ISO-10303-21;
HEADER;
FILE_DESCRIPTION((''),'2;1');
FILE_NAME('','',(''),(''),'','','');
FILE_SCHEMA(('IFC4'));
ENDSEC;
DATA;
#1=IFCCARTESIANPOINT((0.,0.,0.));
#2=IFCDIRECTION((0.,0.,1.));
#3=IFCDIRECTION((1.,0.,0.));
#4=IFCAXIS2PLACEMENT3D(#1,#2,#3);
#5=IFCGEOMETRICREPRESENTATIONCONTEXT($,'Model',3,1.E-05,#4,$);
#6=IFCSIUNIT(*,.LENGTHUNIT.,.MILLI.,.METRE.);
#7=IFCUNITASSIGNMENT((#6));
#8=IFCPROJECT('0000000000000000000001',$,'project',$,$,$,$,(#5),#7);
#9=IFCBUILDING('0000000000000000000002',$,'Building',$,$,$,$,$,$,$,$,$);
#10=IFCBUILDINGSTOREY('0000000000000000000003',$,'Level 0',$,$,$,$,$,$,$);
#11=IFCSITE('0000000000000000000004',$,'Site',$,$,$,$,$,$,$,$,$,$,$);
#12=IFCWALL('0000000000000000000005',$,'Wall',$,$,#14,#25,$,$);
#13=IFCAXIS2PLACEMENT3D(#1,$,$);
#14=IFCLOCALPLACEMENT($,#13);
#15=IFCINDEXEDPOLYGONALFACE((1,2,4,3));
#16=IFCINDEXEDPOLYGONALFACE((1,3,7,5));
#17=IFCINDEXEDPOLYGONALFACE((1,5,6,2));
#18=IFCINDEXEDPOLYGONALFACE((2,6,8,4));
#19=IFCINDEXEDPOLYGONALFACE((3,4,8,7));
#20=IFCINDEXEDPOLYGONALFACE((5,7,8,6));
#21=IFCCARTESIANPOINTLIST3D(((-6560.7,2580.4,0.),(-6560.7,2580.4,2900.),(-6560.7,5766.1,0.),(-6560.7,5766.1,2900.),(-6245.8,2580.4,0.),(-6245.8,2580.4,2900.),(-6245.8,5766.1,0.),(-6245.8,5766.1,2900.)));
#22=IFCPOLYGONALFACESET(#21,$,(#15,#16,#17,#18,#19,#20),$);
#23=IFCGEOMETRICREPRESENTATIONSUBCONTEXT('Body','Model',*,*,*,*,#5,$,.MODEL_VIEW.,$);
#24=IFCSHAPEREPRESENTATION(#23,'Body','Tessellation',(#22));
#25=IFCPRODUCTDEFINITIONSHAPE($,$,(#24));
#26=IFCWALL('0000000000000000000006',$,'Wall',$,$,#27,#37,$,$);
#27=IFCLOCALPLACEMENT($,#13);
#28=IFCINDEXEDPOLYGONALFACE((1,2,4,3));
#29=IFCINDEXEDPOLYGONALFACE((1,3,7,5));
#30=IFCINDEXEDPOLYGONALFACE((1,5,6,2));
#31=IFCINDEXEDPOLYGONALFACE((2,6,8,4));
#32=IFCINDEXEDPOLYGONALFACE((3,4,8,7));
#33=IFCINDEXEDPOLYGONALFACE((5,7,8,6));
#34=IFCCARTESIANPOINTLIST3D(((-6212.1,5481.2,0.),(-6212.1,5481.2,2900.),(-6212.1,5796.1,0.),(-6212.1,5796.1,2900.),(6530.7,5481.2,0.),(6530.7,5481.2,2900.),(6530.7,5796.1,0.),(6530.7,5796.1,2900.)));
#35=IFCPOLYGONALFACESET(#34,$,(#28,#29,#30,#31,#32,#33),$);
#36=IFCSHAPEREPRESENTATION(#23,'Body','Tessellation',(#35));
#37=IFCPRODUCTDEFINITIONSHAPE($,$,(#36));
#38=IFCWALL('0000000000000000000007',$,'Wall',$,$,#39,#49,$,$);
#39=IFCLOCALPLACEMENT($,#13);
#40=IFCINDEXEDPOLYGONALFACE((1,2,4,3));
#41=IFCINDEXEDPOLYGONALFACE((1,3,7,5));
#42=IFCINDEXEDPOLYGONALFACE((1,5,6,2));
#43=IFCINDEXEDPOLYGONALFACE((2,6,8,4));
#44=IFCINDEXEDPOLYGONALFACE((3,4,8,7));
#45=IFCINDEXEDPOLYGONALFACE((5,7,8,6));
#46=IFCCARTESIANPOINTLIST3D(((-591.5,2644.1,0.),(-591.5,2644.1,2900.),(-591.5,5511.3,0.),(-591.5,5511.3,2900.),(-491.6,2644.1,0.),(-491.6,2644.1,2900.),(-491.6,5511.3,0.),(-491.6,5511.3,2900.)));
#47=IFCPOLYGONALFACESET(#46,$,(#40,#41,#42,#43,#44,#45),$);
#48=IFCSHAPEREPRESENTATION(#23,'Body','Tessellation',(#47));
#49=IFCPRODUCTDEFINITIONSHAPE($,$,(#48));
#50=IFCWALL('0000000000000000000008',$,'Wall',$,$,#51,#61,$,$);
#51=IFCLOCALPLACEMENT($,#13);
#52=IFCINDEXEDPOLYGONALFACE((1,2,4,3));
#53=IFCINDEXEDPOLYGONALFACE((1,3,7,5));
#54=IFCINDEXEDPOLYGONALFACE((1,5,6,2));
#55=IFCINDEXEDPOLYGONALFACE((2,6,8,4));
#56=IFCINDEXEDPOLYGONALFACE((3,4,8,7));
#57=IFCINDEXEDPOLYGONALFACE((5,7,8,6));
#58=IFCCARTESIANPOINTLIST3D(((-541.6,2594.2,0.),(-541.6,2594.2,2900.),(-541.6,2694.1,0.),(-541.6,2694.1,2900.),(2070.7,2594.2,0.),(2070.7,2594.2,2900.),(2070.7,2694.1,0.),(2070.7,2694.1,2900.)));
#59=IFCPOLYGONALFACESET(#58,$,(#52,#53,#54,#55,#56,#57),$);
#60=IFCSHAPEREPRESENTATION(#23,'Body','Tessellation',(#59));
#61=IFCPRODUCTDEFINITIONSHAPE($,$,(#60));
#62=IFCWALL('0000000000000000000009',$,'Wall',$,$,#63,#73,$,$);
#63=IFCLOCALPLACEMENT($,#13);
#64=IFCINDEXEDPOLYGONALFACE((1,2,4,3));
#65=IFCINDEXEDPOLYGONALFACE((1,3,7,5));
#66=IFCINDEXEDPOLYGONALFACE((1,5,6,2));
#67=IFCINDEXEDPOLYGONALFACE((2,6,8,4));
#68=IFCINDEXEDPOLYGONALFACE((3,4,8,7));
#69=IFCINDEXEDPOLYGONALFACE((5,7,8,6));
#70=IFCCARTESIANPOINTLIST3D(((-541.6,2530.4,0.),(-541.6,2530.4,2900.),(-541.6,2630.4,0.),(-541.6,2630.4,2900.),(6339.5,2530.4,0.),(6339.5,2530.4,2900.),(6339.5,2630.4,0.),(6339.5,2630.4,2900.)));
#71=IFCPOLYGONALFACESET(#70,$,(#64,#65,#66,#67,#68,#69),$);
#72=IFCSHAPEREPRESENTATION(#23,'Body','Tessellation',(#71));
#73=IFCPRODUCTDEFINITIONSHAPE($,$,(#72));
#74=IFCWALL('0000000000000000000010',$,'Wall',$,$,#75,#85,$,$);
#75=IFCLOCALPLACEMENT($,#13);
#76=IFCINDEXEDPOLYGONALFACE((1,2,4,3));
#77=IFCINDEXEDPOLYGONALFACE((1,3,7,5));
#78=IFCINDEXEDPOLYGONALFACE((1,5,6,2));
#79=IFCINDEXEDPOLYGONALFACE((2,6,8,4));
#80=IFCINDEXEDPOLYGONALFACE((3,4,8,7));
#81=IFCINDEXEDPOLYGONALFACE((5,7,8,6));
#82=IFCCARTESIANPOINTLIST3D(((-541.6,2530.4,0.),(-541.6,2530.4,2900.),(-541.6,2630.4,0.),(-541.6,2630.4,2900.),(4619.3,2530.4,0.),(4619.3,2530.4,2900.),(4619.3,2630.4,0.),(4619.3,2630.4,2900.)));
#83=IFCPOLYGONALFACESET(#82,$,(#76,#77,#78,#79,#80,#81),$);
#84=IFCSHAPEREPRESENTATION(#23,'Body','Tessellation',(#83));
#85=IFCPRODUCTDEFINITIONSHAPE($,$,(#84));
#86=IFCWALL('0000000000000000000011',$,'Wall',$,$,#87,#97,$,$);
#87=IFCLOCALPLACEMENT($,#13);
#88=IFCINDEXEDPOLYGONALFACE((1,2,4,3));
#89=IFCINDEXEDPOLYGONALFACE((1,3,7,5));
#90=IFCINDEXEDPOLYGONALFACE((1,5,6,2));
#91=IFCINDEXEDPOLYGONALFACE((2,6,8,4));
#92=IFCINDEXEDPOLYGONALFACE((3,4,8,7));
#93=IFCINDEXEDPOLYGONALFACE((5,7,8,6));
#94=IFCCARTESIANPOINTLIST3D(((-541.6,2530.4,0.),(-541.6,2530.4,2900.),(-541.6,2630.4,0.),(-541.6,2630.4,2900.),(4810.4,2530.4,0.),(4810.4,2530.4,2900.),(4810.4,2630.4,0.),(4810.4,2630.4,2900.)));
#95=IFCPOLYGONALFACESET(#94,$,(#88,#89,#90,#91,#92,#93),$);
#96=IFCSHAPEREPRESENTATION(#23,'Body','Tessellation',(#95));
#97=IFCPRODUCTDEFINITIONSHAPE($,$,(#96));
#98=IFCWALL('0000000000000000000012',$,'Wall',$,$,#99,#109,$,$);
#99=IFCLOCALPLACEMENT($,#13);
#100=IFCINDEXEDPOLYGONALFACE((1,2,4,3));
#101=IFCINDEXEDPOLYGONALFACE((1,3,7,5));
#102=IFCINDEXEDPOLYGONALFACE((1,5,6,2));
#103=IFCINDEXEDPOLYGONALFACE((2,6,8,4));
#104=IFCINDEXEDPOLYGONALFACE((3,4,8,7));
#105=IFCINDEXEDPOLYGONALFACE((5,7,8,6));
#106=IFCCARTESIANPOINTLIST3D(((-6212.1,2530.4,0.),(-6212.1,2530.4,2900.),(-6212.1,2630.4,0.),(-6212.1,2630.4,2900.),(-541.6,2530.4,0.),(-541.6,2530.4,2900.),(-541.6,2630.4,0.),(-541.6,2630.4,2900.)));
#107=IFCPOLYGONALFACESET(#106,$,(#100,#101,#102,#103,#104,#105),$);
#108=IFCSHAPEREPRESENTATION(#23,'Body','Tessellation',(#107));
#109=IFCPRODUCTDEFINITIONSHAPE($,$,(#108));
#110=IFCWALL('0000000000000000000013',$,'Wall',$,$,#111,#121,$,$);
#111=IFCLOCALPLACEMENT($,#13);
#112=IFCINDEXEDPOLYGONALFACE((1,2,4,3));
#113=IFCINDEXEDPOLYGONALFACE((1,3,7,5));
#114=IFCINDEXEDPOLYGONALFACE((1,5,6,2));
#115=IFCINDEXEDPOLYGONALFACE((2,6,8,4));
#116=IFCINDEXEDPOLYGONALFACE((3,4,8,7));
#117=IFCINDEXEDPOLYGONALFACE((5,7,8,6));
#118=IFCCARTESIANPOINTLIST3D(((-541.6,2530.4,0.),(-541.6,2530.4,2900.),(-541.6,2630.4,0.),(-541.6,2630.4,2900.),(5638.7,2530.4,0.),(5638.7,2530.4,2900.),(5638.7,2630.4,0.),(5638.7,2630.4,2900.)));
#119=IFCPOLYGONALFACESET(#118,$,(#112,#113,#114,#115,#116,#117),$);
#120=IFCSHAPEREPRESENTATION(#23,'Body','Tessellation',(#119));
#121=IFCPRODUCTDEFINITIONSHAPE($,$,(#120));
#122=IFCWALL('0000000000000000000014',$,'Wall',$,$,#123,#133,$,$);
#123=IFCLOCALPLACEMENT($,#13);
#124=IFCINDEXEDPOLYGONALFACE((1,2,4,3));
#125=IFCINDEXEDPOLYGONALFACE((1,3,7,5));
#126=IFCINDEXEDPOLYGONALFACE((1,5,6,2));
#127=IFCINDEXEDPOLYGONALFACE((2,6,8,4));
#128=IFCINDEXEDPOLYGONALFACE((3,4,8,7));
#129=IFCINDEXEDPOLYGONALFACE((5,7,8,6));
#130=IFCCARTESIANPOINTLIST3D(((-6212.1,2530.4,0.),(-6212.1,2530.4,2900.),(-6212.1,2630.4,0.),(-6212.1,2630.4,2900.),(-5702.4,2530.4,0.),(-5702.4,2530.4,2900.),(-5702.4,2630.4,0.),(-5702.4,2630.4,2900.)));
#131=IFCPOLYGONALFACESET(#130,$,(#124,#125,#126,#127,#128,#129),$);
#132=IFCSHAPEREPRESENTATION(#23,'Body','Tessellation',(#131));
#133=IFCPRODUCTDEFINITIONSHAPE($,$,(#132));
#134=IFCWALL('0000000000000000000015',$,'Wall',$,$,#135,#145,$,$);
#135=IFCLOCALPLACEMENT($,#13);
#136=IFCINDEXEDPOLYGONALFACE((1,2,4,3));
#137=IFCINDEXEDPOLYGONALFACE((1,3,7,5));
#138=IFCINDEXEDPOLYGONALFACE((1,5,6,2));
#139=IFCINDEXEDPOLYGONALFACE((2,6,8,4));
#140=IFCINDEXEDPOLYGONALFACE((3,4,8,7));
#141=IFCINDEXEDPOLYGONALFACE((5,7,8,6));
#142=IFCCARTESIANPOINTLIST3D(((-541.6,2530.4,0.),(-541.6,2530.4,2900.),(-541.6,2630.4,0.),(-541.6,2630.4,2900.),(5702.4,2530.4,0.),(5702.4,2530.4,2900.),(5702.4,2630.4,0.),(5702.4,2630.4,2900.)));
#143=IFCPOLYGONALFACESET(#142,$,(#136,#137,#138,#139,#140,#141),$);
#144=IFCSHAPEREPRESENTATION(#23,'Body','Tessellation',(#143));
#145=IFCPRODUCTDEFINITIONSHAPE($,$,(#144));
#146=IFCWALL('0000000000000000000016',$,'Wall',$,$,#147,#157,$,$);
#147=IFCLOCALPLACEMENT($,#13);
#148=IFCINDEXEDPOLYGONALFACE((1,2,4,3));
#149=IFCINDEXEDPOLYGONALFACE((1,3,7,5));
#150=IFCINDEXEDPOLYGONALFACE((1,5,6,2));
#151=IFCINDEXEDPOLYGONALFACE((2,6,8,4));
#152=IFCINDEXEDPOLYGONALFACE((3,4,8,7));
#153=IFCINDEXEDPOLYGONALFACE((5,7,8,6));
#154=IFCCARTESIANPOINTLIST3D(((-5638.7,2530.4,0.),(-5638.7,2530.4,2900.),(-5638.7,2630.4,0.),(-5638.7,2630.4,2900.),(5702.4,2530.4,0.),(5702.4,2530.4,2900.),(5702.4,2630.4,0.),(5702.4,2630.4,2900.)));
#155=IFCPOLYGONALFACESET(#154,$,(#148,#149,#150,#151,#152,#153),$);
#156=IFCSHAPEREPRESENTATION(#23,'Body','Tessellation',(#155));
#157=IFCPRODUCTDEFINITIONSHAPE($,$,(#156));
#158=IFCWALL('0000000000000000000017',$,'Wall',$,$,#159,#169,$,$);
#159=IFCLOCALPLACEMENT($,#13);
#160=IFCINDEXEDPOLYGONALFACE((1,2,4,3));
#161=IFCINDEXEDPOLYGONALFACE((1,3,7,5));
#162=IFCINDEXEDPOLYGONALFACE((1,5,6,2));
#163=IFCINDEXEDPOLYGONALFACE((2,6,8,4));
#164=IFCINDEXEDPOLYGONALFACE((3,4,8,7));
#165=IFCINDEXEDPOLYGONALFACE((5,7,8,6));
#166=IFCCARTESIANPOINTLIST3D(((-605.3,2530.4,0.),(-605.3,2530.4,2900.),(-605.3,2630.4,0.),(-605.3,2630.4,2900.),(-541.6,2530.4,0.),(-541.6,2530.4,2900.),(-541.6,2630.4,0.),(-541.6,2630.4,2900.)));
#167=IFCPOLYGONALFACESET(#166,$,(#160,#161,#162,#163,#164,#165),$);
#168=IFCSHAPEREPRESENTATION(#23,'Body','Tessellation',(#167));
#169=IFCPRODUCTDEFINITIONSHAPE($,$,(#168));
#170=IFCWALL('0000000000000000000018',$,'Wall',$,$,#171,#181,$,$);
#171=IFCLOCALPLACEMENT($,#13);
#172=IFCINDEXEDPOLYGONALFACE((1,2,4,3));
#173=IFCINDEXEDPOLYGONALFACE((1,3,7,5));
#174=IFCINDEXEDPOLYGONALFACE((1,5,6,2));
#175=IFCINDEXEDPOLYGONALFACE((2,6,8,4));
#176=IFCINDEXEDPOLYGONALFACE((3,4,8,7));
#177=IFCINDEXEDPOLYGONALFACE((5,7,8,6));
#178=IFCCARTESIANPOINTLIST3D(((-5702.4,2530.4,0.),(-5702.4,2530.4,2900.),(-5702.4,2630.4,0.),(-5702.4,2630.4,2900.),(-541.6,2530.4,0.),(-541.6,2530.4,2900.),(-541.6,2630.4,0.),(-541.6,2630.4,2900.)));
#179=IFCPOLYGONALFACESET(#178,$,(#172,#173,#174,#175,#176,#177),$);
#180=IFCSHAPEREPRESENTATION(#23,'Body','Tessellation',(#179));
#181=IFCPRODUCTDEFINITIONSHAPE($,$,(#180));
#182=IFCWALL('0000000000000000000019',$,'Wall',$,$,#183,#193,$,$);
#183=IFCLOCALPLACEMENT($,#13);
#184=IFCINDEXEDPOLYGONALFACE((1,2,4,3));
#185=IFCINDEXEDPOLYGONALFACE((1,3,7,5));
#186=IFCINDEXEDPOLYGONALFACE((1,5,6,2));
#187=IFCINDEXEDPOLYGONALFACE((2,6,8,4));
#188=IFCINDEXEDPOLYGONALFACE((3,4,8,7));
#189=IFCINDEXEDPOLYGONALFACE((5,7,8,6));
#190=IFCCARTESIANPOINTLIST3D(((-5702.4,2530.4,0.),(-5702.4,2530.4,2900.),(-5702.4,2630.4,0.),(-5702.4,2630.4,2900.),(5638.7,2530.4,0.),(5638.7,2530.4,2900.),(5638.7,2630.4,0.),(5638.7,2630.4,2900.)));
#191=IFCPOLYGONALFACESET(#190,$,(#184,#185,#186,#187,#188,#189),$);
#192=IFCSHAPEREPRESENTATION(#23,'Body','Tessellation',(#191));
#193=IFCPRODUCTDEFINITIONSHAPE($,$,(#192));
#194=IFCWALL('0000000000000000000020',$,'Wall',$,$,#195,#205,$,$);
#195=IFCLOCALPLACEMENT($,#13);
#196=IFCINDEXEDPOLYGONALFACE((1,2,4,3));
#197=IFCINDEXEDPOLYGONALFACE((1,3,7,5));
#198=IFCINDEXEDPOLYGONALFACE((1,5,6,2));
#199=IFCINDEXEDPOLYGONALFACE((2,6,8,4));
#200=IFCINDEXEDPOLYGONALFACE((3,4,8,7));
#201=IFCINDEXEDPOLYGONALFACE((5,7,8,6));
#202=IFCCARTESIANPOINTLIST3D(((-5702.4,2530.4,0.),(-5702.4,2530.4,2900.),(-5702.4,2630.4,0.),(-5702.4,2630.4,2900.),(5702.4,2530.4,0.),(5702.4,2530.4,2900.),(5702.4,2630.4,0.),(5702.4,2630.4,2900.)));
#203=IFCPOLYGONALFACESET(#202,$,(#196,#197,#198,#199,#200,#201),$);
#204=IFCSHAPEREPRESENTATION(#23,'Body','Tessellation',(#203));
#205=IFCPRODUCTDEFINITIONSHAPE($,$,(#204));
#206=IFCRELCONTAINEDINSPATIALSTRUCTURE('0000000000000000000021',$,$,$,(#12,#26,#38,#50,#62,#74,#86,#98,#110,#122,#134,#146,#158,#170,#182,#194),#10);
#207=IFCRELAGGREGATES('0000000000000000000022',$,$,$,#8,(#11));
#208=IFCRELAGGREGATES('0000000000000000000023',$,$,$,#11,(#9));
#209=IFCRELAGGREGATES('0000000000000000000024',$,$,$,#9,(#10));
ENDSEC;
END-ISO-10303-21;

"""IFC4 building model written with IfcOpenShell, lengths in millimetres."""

from ifc_helpers import new_model, si_unit, frame, origin_with_axes, place, context, subcontext, project, spatial, indexed_curve, outline, extrude, element, save


model = new_model("IFC4")

# Units and contexts
model_context = context("Model", 3, precision=1e-05, world=origin_with_axes())
body_context = subcontext(model_context, "Body", "Model", "MODEL_VIEW")
ifc_project = project(units=[si_unit("LENGTHUNIT", "METRE", prefix="MILLI")], contexts=[model_context])

# Site, building, storey
site = spatial("IfcSite", under=ifc_project, Name="Site")
building = spatial("IfcBuilding", under=site, Name="Building")
storey = spatial("IfcBuildingStorey", under=building, Name="Level 0")

# Walls
wall_1_placement = place(None, frame((-6560.7, 5766.1, 0.0), z_axis=(0.0, 0.0, 1.0), x_axis=(0.0, -1.0, 0.0)))
element("IfcWall", 1, at=wall_1_placement, inside=storey, Name="Wall", context=body_context, shape_type="SweptSolid", body=[
    extrude(outline(indexed_curve([(0.0, 0.0), (0.0, 314.9), (3185.7, 314.9), (3185.7, 0.0), (0.0, 0.0)], self_intersect=False)), origin_with_axes(), (0.0, 0.0, 1.0), 2900.0),
])
wall_2_placement = place(None, frame((-6212.1, 5481.2, 0.0), z_axis=(0.0, 0.0, 1.0), x_axis=(1.0, 0.0, 0.0)))
element("IfcWall", 2, at=wall_2_placement, inside=storey, Name="Wall", context=body_context, shape_type="SweptSolid", body=[
    extrude(outline(indexed_curve([(0.0, 0.0), (0.0, 314.9), (12742.8, 314.9), (12742.8, 0.0), (0.0, 0.0)], self_intersect=False)), origin_with_axes(), (0.0, 0.0, 1.0), 2900.0),
])
wall_3_placement = place(None, frame((-591.5, 5511.3, 0.0), z_axis=(0.0, 0.0, 1.0), x_axis=(0.0, -1.0, 0.0)))
element("IfcWall", 3, at=wall_3_placement, inside=storey, Name="Wall", context=body_context, shape_type="SweptSolid", body=[
    extrude(outline(indexed_curve([(0.0, 0.0), (0.0, 99.9), (2867.1, 99.9), (2867.1, 0.0), (0.0, 0.0)], self_intersect=False)), origin_with_axes(), (0.0, 0.0, 1.0), 2900.0),
])
wall_4_placement = place(None, frame((-541.6, 2594.2, 0.0), z_axis=(0.0, 0.0, 1.0), x_axis=(1.0, 0.0, 0.0)))
element("IfcWall", 4, at=wall_4_placement, inside=storey, Name="Wall", context=body_context, shape_type="SweptSolid", body=[
    extrude(outline(indexed_curve([(0.0, 0.0), (0.0, 99.9), (2612.3, 99.9), (2612.3, 0.0), (0.0, 0.0)], self_intersect=False)), origin_with_axes(), (0.0, 0.0, 1.0), 2900.0),
])
wall_5_placement = place(None, frame((-541.6, 2530.4, 0.0), z_axis=(0.0, 0.0, 1.0), x_axis=(1.0, 0.0, 0.0)))
element("IfcWall", 5, at=wall_5_placement, inside=storey, Name="Wall", context=body_context, shape_type="SweptSolid", body=[
    extrude(outline(indexed_curve([(0.0, 0.0), (0.0, 99.9), (6881.1, 99.9), (6881.1, 0.0), (0.0, 0.0)], self_intersect=False)), origin_with_axes(), (0.0, 0.0, 1.0), 2900.0),
])
wall_6_placement = place(None, frame((-541.6, 2530.4, 0.0), z_axis=(0.0, 0.0, 1.0), x_axis=(1.0, 0.0, 0.0)))
element("IfcWall", 6, at=wall_6_placement, inside=storey, Name="Wall", context=body_context, shape_type="SweptSolid", body=[
    extrude(outline(indexed_curve([(0.0, 0.0), (0.0, 99.9), (5160.8, 99.9), (5160.8, 0.0), (0.0, 0.0)], self_intersect=False)), origin_with_axes(), (0.0, 0.0, 1.0), 2900.0),
])
for number, where, z_axis, x_axis, name in (
    (7, (-541.6, 2530.4, 0.0), (0.0, 0.0, 1.0), (1.0, 0.0, 0.0), "Wall"),
):
    element("IfcWall", number, at=place(None, frame(where, z_axis=z_axis, x_axis=x_axis)), inside=storey, Name=name, context=body_context, shape_type="SweptSolid", body=[
        extrude(outline(indexed_curve([(0.0, 0.0), (0.0, 99.9), (5352.0, 99.9), (5352.0, 0.0), (0.0, 0.0)], self_intersect=False)), origin_with_axes(), (0.0, 0.0, 1.0), 2900.0),
    ])
for number, where, z_axis, x_axis, name in (
    (8, (-6212.1, 2530.4, 0.0), (0.0, 0.0, 1.0), (1.0, 0.0, 0.0), "Wall"),
):
    element("IfcWall", number, at=place(None, frame(where, z_axis=z_axis, x_axis=x_axis)), inside=storey, Name=name, context=body_context, shape_type="SweptSolid", body=[
        extrude(outline(indexed_curve([(0.0, 0.0), (0.0, 99.9), (5670.5, 99.9), (5670.5, 0.0), (0.0, 0.0)], self_intersect=False)), origin_with_axes(), (0.0, 0.0, 1.0), 2900.0),
    ])
wall_7_placement = place(None, frame((-541.6, 2530.4, 0.0), z_axis=(0.0, 0.0, 1.0), x_axis=(1.0, 0.0, 0.0)))
element("IfcWall", 9, at=wall_7_placement, inside=storey, Name="Wall", context=body_context, shape_type="SweptSolid", body=[
    extrude(outline(indexed_curve([(0.0, 0.0), (0.0, 99.9), (6180.3, 99.9), (6180.3, 0.0), (0.0, 0.0)], self_intersect=False)), origin_with_axes(), (0.0, 0.0, 1.0), 2900.0),
])
wall_8_placement = place(None, frame((-6212.1, 2530.4, 0.0), z_axis=(0.0, 0.0, 1.0), x_axis=(1.0, 0.0, 0.0)))
element("IfcWall", 10, at=wall_8_placement, inside=storey, Name="Wall", context=body_context, shape_type="SweptSolid", body=[
    extrude(outline(indexed_curve([(0.0, 0.0), (0.0, 99.9), (509.7, 99.9), (509.7, 0.0), (0.0, 0.0)], self_intersect=False)), origin_with_axes(), (0.0, 0.0, 1.0), 2900.0),
])
wall_9_placement = place(None, frame((-541.6, 2530.4, 0.0), z_axis=(0.0, 0.0, 1.0), x_axis=(1.0, 0.0, 0.0)))
element("IfcWall", 11, at=wall_9_placement, inside=storey, Name="Wall", context=body_context, shape_type="SweptSolid", body=[
    extrude(outline(indexed_curve([(0.0, 0.0), (0.0, 99.9), (6244.0, 99.9), (6244.0, 0.0), (0.0, 0.0)], self_intersect=False)), origin_with_axes(), (0.0, 0.0, 1.0), 2900.0),
])
wall_10_placement = place(None, frame((-5638.7, 2530.4, 0.0), z_axis=(0.0, 0.0, 1.0), x_axis=(1.0, 0.0, 0.0)))
element("IfcWall", 12, at=wall_10_placement, inside=storey, Name="Wall", context=body_context, shape_type="SweptSolid", body=[
    extrude(outline(indexed_curve([(0.0, 0.0), (0.0, 99.9), (11341.1, 99.9), (11341.1, 0.0), (0.0, 0.0)], self_intersect=False)), origin_with_axes(), (0.0, 0.0, 1.0), 2900.0),
])
wall_11_placement = place(None, frame((-605.3, 2530.4, 0.0), z_axis=(0.0, 0.0, 1.0), x_axis=(1.0, 0.0, 0.0)))
element("IfcWall", 13, at=wall_11_placement, inside=storey, Name="Wall", context=body_context, shape_type="SweptSolid", body=[
    extrude(outline(indexed_curve([(0.0, 0.0), (0.0, 99.9), (63.7, 99.9), (63.7, 0.0), (0.0, 0.0)], self_intersect=False)), origin_with_axes(), (0.0, 0.0, 1.0), 2900.0),
])
wall_12_placement = place(None, frame((-5702.4, 2530.4, 0.0), z_axis=(0.0, 0.0, 1.0), x_axis=(1.0, 0.0, 0.0)))
element("IfcWall", 14, at=wall_12_placement, inside=storey, Name="Wall", context=body_context, shape_type="SweptSolid", body=[
    extrude(outline(indexed_curve([(0.0, 0.0), (0.0, 99.9), (5160.8, 99.9), (5160.8, 0.0), (0.0, 0.0)], self_intersect=False)), origin_with_axes(), (0.0, 0.0, 1.0), 2900.0),
])
for number, where, z_axis, x_axis, name in (
    (15, (-5702.4, 2530.4, 0.0), (0.0, 0.0, 1.0), (1.0, 0.0, 0.0), "Wall"),
):
    element("IfcWall", number, at=place(None, frame(where, z_axis=z_axis, x_axis=x_axis)), inside=storey, Name=name, context=body_context, shape_type="SweptSolid", body=[
        extrude(outline(indexed_curve([(0.0, 0.0), (0.0, 99.9), (11341.1, 99.9), (11341.1, 0.0), (0.0, 0.0)], self_intersect=False)), origin_with_axes(), (0.0, 0.0, 1.0), 2900.0),
    ])
wall_13_placement = place(None, frame((-5702.4, 2530.4, 0.0), z_axis=(0.0, 0.0, 1.0), x_axis=(1.0, 0.0, 0.0)))
element("IfcWall", 16, at=wall_13_placement, inside=storey, Name="Wall", context=body_context, shape_type="SweptSolid", body=[
    extrude(outline(indexed_curve([(0.0, 0.0), (0.0, 99.9), (11404.8, 99.9), (11404.8, 0.0), (0.0, 0.0)], self_intersect=False)), origin_with_axes(), (0.0, 0.0, 1.0), 2900.0),
])

save(model, "model.ifc")
